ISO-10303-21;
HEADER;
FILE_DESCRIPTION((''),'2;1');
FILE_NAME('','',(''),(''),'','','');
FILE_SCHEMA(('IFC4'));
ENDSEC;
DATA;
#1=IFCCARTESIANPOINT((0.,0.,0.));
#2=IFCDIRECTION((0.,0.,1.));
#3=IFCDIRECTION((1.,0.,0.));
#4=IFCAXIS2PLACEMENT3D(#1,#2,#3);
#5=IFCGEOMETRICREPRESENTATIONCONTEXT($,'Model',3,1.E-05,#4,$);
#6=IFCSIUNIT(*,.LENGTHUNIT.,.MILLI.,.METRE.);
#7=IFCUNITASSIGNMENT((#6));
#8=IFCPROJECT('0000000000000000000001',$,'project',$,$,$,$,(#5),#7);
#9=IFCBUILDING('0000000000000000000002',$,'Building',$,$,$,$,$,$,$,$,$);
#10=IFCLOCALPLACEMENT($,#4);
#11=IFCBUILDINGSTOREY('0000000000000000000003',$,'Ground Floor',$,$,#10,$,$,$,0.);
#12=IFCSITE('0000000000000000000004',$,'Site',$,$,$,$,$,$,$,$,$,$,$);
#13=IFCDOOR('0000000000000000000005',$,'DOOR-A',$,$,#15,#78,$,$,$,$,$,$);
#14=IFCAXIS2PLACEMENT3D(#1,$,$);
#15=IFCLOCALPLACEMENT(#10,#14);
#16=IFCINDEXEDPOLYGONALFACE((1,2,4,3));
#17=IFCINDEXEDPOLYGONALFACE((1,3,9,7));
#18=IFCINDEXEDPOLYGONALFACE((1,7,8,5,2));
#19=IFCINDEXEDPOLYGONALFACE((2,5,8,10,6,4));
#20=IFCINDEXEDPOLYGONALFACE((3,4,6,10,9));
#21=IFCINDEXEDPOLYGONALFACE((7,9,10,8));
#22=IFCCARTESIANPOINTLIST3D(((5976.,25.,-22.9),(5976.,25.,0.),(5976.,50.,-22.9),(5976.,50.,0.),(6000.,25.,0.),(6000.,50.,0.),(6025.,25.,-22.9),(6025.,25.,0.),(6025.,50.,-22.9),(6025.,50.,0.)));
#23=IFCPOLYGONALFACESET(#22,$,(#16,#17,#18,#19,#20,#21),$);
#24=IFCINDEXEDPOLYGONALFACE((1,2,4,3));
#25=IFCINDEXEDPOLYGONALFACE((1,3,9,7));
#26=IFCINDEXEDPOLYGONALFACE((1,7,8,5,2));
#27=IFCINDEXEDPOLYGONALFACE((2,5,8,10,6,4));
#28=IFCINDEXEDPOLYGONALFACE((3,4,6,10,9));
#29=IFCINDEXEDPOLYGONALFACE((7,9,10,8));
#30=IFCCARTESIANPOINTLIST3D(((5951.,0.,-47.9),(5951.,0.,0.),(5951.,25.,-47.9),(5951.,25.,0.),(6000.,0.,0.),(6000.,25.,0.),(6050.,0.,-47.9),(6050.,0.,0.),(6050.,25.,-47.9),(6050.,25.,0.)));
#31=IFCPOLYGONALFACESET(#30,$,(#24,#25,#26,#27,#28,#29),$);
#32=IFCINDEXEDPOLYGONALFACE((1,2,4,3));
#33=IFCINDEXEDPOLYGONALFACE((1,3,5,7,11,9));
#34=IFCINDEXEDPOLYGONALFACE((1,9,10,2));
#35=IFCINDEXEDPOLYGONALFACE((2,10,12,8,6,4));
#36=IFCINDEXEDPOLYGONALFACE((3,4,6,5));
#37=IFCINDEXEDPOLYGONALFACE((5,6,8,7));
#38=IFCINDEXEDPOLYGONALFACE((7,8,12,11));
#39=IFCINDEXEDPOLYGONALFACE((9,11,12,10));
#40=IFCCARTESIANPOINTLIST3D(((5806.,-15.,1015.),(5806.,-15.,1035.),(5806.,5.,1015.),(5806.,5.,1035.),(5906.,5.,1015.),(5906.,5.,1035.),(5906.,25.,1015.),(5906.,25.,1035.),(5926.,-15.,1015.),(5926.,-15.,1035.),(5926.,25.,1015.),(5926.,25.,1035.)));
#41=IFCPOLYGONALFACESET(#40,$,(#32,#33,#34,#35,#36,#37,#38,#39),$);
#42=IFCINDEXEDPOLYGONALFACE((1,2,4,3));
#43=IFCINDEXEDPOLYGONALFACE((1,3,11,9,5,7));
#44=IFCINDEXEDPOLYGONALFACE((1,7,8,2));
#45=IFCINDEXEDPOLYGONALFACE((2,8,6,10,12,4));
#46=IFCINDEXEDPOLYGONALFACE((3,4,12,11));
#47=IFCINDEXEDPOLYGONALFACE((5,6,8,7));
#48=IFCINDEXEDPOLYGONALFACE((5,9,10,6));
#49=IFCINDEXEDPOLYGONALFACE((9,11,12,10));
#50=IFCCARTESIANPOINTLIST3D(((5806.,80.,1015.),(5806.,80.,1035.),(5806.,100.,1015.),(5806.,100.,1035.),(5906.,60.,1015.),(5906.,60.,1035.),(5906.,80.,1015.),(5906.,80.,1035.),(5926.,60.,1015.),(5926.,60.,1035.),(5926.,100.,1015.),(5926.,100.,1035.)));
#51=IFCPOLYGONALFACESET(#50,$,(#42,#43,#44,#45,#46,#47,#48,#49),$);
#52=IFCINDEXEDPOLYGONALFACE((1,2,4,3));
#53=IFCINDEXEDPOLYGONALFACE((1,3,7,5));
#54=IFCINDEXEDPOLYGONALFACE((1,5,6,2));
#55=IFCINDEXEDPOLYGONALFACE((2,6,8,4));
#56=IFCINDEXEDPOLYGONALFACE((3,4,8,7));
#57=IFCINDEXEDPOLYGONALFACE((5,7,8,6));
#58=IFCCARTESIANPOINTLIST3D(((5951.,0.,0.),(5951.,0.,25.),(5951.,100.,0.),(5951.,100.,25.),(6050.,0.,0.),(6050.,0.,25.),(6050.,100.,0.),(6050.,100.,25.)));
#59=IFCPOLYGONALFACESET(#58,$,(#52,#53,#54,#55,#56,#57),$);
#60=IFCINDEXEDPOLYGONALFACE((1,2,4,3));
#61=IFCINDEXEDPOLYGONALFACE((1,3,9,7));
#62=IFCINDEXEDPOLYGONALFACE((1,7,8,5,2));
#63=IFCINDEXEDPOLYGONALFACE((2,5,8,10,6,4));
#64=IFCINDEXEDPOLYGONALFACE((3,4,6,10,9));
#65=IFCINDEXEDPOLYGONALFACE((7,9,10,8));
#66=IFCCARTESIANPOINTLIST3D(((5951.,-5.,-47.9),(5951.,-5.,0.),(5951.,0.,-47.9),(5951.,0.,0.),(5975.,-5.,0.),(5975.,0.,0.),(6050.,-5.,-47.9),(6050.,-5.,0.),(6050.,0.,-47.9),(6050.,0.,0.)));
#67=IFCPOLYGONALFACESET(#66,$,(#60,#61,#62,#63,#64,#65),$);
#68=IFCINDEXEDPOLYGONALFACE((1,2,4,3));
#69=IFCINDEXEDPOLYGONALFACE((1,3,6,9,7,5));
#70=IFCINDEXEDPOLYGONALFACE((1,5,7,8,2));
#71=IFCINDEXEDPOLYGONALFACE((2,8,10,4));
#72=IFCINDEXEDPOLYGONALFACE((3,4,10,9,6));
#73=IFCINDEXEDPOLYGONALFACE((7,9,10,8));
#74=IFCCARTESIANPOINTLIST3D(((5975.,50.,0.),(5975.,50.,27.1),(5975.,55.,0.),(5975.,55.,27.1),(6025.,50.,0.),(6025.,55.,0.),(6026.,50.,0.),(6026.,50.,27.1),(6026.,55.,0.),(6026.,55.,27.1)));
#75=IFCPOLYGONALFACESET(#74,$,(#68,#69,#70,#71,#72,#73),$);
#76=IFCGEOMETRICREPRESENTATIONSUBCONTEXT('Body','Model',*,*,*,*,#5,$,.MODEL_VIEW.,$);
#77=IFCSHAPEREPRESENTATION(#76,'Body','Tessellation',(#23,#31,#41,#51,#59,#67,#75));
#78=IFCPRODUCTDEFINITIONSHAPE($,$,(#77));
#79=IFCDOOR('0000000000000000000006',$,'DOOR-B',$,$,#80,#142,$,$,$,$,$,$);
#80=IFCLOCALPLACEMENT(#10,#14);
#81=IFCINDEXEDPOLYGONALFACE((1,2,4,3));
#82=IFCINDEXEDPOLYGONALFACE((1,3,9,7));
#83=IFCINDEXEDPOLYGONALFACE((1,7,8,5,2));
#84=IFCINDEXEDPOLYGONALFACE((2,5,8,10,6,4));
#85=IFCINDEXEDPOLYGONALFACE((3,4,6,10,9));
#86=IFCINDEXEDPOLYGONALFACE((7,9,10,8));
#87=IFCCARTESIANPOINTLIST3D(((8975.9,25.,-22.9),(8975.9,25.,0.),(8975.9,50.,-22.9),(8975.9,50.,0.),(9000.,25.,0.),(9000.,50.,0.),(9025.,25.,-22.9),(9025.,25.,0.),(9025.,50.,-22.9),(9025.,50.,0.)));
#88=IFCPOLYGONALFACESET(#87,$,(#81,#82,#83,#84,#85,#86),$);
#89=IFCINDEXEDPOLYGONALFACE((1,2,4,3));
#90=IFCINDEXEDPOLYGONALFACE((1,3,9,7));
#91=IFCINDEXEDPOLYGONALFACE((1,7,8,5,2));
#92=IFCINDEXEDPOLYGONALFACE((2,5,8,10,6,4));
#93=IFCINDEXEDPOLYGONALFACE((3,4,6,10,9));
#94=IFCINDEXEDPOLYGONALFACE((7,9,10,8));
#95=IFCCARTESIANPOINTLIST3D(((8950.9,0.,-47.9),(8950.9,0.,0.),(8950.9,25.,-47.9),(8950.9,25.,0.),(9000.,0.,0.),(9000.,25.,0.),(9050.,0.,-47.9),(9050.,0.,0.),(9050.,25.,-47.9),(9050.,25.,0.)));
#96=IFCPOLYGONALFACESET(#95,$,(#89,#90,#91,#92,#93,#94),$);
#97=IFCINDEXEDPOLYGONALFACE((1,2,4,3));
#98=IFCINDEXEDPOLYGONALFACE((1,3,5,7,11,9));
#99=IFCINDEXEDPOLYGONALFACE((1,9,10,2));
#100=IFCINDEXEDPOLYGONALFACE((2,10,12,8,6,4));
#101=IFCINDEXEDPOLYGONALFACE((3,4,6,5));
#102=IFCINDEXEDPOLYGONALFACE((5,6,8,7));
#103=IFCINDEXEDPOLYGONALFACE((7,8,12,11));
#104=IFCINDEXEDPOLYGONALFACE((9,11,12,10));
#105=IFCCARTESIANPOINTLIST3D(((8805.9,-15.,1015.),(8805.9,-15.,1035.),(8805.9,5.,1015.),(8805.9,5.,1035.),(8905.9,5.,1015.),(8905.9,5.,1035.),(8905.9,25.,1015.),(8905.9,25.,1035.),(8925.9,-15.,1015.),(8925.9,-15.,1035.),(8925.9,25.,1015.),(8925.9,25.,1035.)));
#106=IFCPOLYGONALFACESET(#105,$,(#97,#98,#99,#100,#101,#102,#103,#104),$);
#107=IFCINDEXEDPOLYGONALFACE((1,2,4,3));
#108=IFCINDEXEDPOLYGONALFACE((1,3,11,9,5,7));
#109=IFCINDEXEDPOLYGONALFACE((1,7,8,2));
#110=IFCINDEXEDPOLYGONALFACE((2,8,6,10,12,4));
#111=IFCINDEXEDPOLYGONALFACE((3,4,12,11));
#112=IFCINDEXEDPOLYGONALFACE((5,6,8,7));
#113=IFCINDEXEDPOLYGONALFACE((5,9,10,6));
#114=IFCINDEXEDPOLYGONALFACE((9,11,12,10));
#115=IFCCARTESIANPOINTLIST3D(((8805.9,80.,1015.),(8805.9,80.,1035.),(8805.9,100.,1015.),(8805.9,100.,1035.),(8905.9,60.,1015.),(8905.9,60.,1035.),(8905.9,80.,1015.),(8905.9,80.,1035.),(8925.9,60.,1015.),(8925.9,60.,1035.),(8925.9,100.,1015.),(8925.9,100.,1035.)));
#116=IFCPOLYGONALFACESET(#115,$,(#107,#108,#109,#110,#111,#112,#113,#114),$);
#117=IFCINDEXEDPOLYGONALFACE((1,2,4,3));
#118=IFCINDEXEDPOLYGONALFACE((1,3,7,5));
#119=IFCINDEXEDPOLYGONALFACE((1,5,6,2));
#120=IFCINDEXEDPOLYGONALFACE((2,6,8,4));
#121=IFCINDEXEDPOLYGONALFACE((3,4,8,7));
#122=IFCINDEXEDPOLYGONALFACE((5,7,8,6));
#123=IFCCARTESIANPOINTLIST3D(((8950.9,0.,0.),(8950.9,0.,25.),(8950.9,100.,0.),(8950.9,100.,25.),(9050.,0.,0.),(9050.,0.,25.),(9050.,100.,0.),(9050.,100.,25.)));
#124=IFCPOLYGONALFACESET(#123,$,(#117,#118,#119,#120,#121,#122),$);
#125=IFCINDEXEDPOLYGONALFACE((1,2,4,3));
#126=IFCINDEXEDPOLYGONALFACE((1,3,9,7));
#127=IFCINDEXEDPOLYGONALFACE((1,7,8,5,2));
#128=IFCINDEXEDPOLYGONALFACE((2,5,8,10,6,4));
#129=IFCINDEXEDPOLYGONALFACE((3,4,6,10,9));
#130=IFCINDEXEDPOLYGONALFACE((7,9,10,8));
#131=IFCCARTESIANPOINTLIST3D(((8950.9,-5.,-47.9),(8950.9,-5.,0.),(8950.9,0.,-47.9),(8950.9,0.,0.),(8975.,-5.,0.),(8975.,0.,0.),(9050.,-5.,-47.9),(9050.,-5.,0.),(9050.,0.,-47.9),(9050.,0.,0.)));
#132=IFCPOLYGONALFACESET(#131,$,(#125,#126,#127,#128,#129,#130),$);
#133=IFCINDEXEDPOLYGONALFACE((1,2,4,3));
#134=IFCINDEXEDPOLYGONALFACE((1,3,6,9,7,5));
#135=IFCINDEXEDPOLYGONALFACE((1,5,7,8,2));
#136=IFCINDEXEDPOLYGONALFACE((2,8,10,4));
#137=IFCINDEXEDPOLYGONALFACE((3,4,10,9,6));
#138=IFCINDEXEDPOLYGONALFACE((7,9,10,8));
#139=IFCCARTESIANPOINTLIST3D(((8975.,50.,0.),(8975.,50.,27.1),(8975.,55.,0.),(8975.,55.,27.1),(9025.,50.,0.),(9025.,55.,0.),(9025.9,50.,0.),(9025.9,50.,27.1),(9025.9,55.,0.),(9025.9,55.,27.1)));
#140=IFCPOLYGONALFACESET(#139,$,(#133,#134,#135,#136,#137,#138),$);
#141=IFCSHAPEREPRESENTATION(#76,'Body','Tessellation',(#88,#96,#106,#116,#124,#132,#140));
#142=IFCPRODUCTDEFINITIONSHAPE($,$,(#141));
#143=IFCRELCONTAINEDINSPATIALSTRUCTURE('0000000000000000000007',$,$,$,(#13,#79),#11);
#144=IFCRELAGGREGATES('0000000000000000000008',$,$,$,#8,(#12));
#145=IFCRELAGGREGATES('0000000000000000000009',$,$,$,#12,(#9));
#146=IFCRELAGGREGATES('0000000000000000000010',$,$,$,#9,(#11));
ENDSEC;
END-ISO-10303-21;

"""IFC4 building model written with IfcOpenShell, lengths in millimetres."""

from ifc_helpers import new_model, si_unit, frame, origin_with_axes, place, context, subcontext, project, spatial, line, indexed_curve, outline, extrude, element, save


model = new_model("IFC4")

# Units and contexts
model_context = context("Model", 3, precision=1e-05, world=origin_with_axes())
body_context = subcontext(model_context, "Body", "Model", "MODEL_VIEW")
ifc_project = project(units=[si_unit("LENGTHUNIT", "METRE", prefix="MILLI")], contexts=[model_context])

# Site, building, storey
site = spatial("IfcSite", under=ifc_project, Name="Site")
building = spatial("IfcBuilding", under=site, Name="Building")
storey_placement = place(None, origin_with_axes())
storey = spatial("IfcBuildingStorey", under=building, at=storey_placement, Name="Ground Floor", Elevation=0.0)

# Doors
door_1_placement = place(storey_placement, frame((6000.0, 0.0, 0.0), z_axis=(0.0, 0.0, 1.0), x_axis=(1.0, 0.0, 0.0)))
element("IfcDoor", 1, at=door_1_placement, inside=storey, Name="DOOR-A", context=body_context, shape_type="SweptSolid", body=[
    extrude(outline(indexed_curve([(0.0, 0.0), (0.0, 2.1), (0.9, 2.1), (0.9, 0.0), (-24.1, 0.0), (-24.1, -22.9), (25.0, -22.9), (25.0, 0.0)], segments=[line(1, 2, 3, 4, 5, 6, 7, 8, 1)])), frame((0.0, 25.0, 0.0), z_axis=(0.0, -1.0, 0.0), x_axis=(1.0, 0.0, 0.0)), (0.0, 0.0, -1.0), 25.0),
    extrude(outline(indexed_curve([(0.0, 0.0), (0.0, 2.1), (0.9, 2.1), (0.9, 0.0), (-49.0, 0.0), (-49.0, -47.9), (50.0, -47.9), (50.0, 0.0)], segments=[line(1, 2, 3, 4, 5, 6, 7, 8, 1)])), frame((0.0, 0.0, 0.0), z_axis=(0.0, -1.0, 0.0), x_axis=(1.0, 0.0, 0.0)), (0.0, 0.0, -1.0), 25.0),
    extrude(outline(indexed_curve([(0.0, 0.0), (-49.0, 0.0), (-49.0, 35.0), (0.0, 35.0)], segments=[line(1, 2, 3, 4, 1)])), frame((25.0, 25.0, 25.0), z_axis=(0.0, 0.0, 1.0), x_axis=(1.0, 0.0, 0.0)), (0.0, 0.0, 1.0), -47.9),
    extrude(outline(indexed_curve([(0.0, 0.0), (0.0, -40.0), (-120.0, -40.0), (-120.0, -20.0), (-20.0, -20.0), (-20.0, 0.0)], segments=[line(1, 2, 3, 4, 5, 6, 1)])), frame((-74.1, 25.0, 1015.0), z_axis=(0.0, 0.0, 1.0), x_axis=(1.0, 0.0, 0.0)), (0.0, 0.0, 1.0), 20.0),
    extrude(outline(indexed_curve([(0.0, 0.0), (0.0, 40.0), (-120.0, 40.0), (-120.0, 20.0), (-20.0, 20.0), (-20.0, 0.0)], segments=[line(1, 2, 3, 4, 5, 6, 1)])), frame((-74.1, 60.0, 1015.0), z_axis=(0.0, 0.0, 1.0), x_axis=(1.0, 0.0, 0.0)), (0.0, 0.0, 1.0), 20.0),
    extrude(outline(indexed_curve([(0.0, 0.0), (-99.0, 0.0), (-99.0, 100.0), (0.0, 100.0)], segments=[line(1, 2, 3, 4, 1)])), frame((50.0, 0.0, 0.0), z_axis=(0.0, 0.0, 1.0), x_axis=(1.0, 0.0, 0.0)), (0.0, 0.0, 1.0), 25.0),
    extrude(outline(indexed_curve([(0.0, 0.0), (0.0, 27.1), (51.0, 27.1), (51.0, 0.0), (-24.0, 0.0), (-24.0, -47.9), (75.0, -47.9), (75.0, 0.0)], segments=[line(1, 2, 3, 4, 5, 6, 7, 8, 1)])), frame((-25.0, -5.0, 0.0), z_axis=(0.0, -1.0, 0.0), x_axis=(1.0, 0.0, 0.0)), (0.0, 0.0, -1.0), 5.0),
    extrude(outline(indexed_curve([(0.0, 0.0), (0.0, 27.1), (51.0, 27.1), (51.0, 0.0), (1.0, 0.0), (1.0, -22.9), (50.0, -22.9), (50.0, 0.0)], segments=[line(1, 2, 3, 4, 5, 6, 7, 8, 1)])), frame((-25.0, 50.0, 0.0), z_axis=(0.0, -1.0, 0.0), x_axis=(1.0, 0.0, 0.0)), (0.0, 0.0, -1.0), 5.0),
])
door_2_placement = place(storey_placement, frame((9000.0, 0.0, 0.0), z_axis=(0.0, 0.0, 1.0), x_axis=(1.0, 0.0, 0.0)))
element("IfcDoor", 2, at=door_2_placement, inside=storey, Name="DOOR-B", context=body_context, shape_type="SweptSolid", body=[
    extrude(outline(indexed_curve([(0.0, 0.0), (0.0, 2.1), (0.9, 2.1), (0.9, 0.0), (-24.1, 0.0), (-24.1, -22.9), (25.0, -22.9), (25.0, 0.0)], segments=[line(1, 2, 3, 4, 5, 6, 7, 8, 1)])), frame((0.0, 25.0, 0.0), z_axis=(0.0, -1.0, 0.0), x_axis=(1.0, 0.0, 0.0)), (0.0, 0.0, -1.0), 25.0),
    extrude(outline(indexed_curve([(0.0, 0.0), (0.0, 2.1), (0.9, 2.1), (0.9, 0.0), (-49.1, 0.0), (-49.1, -47.9), (50.0, -47.9), (50.0, 0.0)], segments=[line(1, 2, 3, 4, 5, 6, 7, 8, 1)])), frame((0.0, 0.0, 0.0), z_axis=(0.0, -1.0, 0.0), x_axis=(1.0, 0.0, 0.0)), (0.0, 0.0, -1.0), 25.0),
    extrude(outline(indexed_curve([(0.0, 0.0), (-49.1, 0.0), (-49.1, 35.0), (0.0, 35.0)], segments=[line(1, 2, 3, 4, 1)])), frame((25.0, 25.0, 25.0), z_axis=(0.0, 0.0, 1.0), x_axis=(1.0, 0.0, 0.0)), (0.0, 0.0, 1.0), -47.9),
    extrude(outline(indexed_curve([(0.0, 0.0), (0.0, -40.0), (-120.0, -40.0), (-120.0, -20.0), (-20.0, -20.0), (-20.0, 0.0)], segments=[line(1, 2, 3, 4, 5, 6, 1)])), frame((-74.1, 25.0, 1015.0), z_axis=(0.0, 0.0, 1.0), x_axis=(1.0, 0.0, 0.0)), (0.0, 0.0, 1.0), 20.0),
    extrude(outline(indexed_curve([(0.0, 0.0), (0.0, 40.0), (-120.0, 40.0), (-120.0, 20.0), (-20.0, 20.0), (-20.0, 0.0)], segments=[line(1, 2, 3, 4, 5, 6, 1)])), frame((-74.1, 60.0, 1015.0), z_axis=(0.0, 0.0, 1.0), x_axis=(1.0, 0.0, 0.0)), (0.0, 0.0, 1.0), 20.0),
    extrude(outline(indexed_curve([(0.0, 0.0), (-99.1, 0.0), (-99.1, 100.0), (0.0, 100.0)], segments=[line(1, 2, 3, 4, 1)])), frame((50.0, 0.0, 0.0), z_axis=(0.0, 0.0, 1.0), x_axis=(1.0, 0.0, 0.0)), (0.0, 0.0, 1.0), 25.0),
    extrude(outline(indexed_curve([(0.0, 0.0), (0.0, 27.1), (50.9, 27.1), (50.9, 0.0), (-24.1, 0.0), (-24.1, -47.9), (75.0, -47.9), (75.0, 0.0)], segments=[line(1, 2, 3, 4, 5, 6, 7, 8, 1)])), frame((-25.0, -5.0, 0.0), z_axis=(0.0, -1.0, 0.0), x_axis=(1.0, 0.0, 0.0)), (0.0, 0.0, -1.0), 5.0),
    extrude(outline(indexed_curve([(0.0, 0.0), (0.0, 27.1), (50.9, 27.1), (50.9, 0.0), (0.9, 0.0), (0.9, -22.9), (50.0, -22.9), (50.0, 0.0)], segments=[line(1, 2, 3, 4, 5, 6, 7, 8, 1)])), frame((-25.0, 50.0, 0.0), z_axis=(0.0, -1.0, 0.0), x_axis=(1.0, 0.0, 0.0)), (0.0, 0.0, -1.0), 5.0),
])

save(model, "model.ifc")
